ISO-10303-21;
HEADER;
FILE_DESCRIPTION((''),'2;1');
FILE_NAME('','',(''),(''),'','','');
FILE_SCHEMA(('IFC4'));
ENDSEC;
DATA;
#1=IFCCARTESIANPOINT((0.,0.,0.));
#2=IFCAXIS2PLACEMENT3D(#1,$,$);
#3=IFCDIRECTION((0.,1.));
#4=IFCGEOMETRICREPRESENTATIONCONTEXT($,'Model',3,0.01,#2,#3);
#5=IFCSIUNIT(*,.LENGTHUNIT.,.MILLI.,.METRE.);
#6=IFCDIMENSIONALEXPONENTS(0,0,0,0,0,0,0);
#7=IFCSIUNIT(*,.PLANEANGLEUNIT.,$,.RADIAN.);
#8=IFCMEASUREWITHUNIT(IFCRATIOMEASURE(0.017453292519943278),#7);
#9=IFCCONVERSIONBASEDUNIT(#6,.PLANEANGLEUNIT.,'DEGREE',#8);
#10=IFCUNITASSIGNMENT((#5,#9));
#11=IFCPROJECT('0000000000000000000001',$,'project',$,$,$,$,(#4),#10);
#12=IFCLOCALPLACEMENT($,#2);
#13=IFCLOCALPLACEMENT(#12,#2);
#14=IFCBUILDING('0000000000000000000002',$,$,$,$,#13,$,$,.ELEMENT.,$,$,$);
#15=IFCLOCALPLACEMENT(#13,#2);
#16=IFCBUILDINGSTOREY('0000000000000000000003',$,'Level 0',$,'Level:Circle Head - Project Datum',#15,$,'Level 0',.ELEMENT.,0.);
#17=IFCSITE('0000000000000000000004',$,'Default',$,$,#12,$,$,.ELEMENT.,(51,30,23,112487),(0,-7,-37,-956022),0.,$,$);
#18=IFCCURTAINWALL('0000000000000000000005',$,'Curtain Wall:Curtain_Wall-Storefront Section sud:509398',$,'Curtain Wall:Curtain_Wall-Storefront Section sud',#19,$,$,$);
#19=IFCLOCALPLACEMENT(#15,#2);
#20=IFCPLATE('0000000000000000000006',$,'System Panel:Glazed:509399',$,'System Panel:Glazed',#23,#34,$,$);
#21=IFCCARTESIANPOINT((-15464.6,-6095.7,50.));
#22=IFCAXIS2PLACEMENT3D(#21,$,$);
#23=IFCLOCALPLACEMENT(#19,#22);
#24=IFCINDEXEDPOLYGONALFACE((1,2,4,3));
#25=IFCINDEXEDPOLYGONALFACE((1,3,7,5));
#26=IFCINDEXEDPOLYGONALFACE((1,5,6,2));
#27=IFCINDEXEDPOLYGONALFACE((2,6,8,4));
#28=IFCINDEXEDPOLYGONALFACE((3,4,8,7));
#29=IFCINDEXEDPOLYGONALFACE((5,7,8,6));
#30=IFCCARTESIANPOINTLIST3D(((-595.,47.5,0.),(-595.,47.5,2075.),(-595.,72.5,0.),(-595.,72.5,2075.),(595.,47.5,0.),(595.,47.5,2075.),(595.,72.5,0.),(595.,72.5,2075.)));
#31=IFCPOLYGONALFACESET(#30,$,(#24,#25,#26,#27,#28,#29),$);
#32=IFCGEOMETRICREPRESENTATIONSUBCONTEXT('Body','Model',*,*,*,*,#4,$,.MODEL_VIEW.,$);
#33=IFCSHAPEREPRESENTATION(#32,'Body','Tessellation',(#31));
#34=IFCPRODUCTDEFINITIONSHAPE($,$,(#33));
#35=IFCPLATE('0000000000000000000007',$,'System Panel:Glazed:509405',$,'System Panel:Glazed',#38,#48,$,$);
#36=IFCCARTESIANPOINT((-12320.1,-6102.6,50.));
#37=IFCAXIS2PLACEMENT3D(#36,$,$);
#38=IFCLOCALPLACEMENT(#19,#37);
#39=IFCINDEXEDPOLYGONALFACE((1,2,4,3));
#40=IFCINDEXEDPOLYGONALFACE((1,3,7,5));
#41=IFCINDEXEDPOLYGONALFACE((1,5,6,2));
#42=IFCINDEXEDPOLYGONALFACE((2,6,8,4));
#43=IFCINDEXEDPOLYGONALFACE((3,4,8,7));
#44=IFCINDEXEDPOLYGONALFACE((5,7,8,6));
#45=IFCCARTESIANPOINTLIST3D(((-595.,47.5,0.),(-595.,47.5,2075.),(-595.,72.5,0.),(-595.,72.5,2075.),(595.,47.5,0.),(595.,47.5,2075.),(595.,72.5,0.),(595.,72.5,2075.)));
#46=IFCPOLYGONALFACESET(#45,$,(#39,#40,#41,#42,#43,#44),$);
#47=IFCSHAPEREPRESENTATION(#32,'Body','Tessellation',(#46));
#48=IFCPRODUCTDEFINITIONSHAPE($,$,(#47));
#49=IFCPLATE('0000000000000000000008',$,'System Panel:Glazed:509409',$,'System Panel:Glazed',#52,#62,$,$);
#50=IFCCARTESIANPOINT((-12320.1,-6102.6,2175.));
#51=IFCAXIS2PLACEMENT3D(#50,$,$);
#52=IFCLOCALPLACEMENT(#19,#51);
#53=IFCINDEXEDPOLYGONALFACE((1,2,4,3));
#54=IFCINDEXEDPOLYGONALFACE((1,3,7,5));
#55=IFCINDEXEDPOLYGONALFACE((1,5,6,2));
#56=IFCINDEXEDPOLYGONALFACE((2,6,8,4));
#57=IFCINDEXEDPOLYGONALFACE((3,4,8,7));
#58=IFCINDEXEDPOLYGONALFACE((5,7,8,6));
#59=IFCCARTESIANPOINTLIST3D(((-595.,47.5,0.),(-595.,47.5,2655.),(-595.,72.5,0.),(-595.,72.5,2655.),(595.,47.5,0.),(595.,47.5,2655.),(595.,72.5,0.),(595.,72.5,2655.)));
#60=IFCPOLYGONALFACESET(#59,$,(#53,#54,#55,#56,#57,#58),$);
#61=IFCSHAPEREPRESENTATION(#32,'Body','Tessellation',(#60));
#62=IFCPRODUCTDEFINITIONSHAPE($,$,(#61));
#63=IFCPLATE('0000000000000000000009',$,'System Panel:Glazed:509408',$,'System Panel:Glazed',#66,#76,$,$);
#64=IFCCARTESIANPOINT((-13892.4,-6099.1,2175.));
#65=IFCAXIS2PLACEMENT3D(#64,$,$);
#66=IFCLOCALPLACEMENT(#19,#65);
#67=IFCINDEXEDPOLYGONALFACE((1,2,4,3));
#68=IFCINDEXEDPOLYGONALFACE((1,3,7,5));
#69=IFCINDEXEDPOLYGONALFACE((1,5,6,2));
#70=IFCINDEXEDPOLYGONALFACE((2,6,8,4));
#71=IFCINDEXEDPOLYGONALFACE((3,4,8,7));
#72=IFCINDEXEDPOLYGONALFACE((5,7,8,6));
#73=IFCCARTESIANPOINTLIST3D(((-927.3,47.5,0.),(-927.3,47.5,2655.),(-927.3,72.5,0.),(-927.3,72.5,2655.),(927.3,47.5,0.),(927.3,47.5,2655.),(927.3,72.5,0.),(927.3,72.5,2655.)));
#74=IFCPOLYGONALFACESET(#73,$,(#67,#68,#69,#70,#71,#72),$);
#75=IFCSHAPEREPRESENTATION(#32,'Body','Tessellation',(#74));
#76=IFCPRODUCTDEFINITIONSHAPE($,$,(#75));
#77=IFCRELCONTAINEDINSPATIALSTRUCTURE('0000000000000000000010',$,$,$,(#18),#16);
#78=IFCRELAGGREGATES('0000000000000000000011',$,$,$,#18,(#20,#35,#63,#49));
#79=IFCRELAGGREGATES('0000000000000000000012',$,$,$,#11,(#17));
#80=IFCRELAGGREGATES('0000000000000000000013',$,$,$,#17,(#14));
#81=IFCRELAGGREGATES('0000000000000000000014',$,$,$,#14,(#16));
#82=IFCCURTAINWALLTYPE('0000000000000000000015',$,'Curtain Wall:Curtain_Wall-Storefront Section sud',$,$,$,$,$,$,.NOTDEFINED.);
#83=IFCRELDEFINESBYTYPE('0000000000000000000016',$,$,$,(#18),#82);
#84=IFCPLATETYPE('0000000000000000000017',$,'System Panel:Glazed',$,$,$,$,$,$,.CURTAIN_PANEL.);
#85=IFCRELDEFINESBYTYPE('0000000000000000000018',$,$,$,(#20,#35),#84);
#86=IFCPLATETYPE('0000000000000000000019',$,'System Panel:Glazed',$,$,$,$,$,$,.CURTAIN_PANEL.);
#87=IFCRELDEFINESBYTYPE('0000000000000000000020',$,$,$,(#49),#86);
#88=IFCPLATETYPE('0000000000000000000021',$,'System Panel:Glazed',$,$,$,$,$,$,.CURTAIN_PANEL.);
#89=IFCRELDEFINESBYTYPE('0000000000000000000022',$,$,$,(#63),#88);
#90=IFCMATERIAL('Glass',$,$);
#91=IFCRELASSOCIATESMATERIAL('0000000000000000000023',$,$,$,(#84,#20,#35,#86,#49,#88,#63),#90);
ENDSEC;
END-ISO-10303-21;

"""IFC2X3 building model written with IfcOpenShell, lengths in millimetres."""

from ifc_helpers import new_model, entity, si_unit, converted_unit, direction, frame, frame_2d, origin, origin_2d_with_axis, place, context, subcontext, project, spatial, rectangle, extrude, source, transform, mapped, material, type_object, type_shapes, element, aggregate, save


model = new_model("IFC2X3")

# Units and contexts
model_context = context("Model", 3, precision=0.01, world=origin(), true_north=direction((0.0, 1.0)))
body_context = subcontext(model_context, "Body", "Model", "MODEL_VIEW")
ifc_project = project(units=[si_unit("LENGTHUNIT", "METRE", prefix="MILLI"), converted_unit("PLANEANGLEUNIT", "DEGREE", entity("IfcRatioMeasure", 0.017453292519943278), si_unit("PLANEANGLEUNIT", "RADIAN"), dimensions=[0, 0, 0, 0, 0, 0, 0])], contexts=[model_context])

# Site, building, storey
site_placement = place(None, origin())
site = spatial("IfcSite", under=ifc_project, at=site_placement, Name="Default", CompositionType="ELEMENT", RefLatitude=(51, 30, 23, 112487), RefLongitude=(0, -7, -37, -956022), RefElevation=0.0)
building_placement = place(site_placement, origin())
building = spatial("IfcBuilding", under=site, at=building_placement, CompositionType="ELEMENT")
storey_placement = place(building_placement, origin())
storey = spatial("IfcBuildingStorey", under=building, at=storey_placement, Name="Level 0", ObjectType="Level:Circle Head - Project Datum", LongName="Level 0", CompositionType="ELEMENT", Elevation=0.0)

# Curtain wall, plates
curtain_wall_type = type_object("IfcCurtainWallType", Name="Curtain Wall:Curtain_Wall-Storefront Section sud", PredefinedType="NOTDEFINED")
curtain_wall_placement = place(storey_placement, origin())
curtain_wall = element("IfcCurtainWall", 1, at=curtain_wall_placement, inside=storey, type_object=curtain_wall_type, Name="Curtain Wall:Curtain_Wall-Storefront Section sud:509398", ObjectType="Curtain Wall:Curtain_Wall-Storefront Section sud")
ifc_material_1 = material(Name="Glass")
plate_type_1 = type_object("IfcPlateType", Name="System Panel:Glazed", PredefinedType="CURTAIN_PANEL", material=ifc_material_1)
shared_shape_1 = source(origin(), body_context, "Body", "SweptSolid", [
    extrude(rectangle(XDim=25.0, YDim=1190.0, at=origin_2d_with_axis()), frame((0.0, 60.0, 0.0), z_axis=(0.0, 0.0, 1.0), x_axis=(0.0, 1.0, 0.0)), (0.0, 0.0, 1.0), 2075.0),
])
type_shapes(plate_type_1, [shared_shape_1])
plate_1_placement = place(curtain_wall_placement, frame((-15464.6, -6095.7, 50.0)))
plate_1 = element("IfcPlate", 2, at=plate_1_placement, type_object=plate_type_1, material=ifc_material_1, Name="System Panel:Glazed:509399", ObjectType="System Panel:Glazed", context=body_context, shape_type="MappedRepresentation", body=[
    mapped(shared_shape_1, transform((0.0, 0.0, 0.0), scale=1.0)),
])
plate_2_placement = place(curtain_wall_placement, frame((-12320.1, -6102.6, 50.0)))
plate_2 = element("IfcPlate", 3, at=plate_2_placement, type_object=plate_type_1, material=ifc_material_1, Name="System Panel:Glazed:509405", ObjectType="System Panel:Glazed", context=body_context, shape_type="MappedRepresentation", body=[
    mapped(shared_shape_1, transform((0.0, 0.0, 0.0), scale=1.0)),
])
plate_type_2 = type_object("IfcPlateType", Name="System Panel:Glazed", PredefinedType="CURTAIN_PANEL", material=ifc_material_1)
shared_shape_2 = source(origin(), body_context, "Body", "SweptSolid", [
    extrude(rectangle(XDim=25.0, YDim=1190.0, at=frame_2d((0.0, 0.0), x_axis=(1.0, 0.0))), frame((0.0, 60.0, 0.0), z_axis=(0.0, 0.0, 1.0), x_axis=(0.0, 1.0, 0.0)), (0.0, 0.0, 1.0), 2655.0),
])
type_shapes(plate_type_2, [shared_shape_2])
plate_3_placement = place(curtain_wall_placement, frame((-12320.1, -6102.6, 2175.0)))
plate_3 = element("IfcPlate", 4, at=plate_3_placement, type_object=plate_type_2, material=ifc_material_1, Name="System Panel:Glazed:509409", ObjectType="System Panel:Glazed", context=body_context, shape_type="MappedRepresentation", body=[
    mapped(shared_shape_2, transform((0.0, 0.0, 0.0), scale=1.0)),
])
plate_type_3 = type_object("IfcPlateType", Name="System Panel:Glazed", PredefinedType="CURTAIN_PANEL", material=ifc_material_1)
shared_shape_3 = source(origin(), body_context, "Body", "SweptSolid", [
    extrude(rectangle(XDim=25.0, YDim=1854.5, at=frame_2d((0.0, 0.0), x_axis=(1.0, 0.0))), frame((0.0, 60.0, 0.0), z_axis=(0.0, 0.0, 1.0), x_axis=(0.0, 1.0, 0.0)), (0.0, 0.0, 1.0), 2655.0),
])
type_shapes(plate_type_3, [shared_shape_3])
plate_4_placement = place(curtain_wall_placement, frame((-13892.4, -6099.1, 2175.0)))
plate_4 = element("IfcPlate", 5, at=plate_4_placement, type_object=plate_type_3, material=ifc_material_1, Name="System Panel:Glazed:509408", ObjectType="System Panel:Glazed", context=body_context, shape_type="MappedRepresentation", body=[
    mapped(shared_shape_3, transform((0.0, 0.0, 0.0), scale=1.0)),
])
aggregate(curtain_wall, [plate_1, plate_2, plate_4, plate_3])

save(model, "model.ifc")
